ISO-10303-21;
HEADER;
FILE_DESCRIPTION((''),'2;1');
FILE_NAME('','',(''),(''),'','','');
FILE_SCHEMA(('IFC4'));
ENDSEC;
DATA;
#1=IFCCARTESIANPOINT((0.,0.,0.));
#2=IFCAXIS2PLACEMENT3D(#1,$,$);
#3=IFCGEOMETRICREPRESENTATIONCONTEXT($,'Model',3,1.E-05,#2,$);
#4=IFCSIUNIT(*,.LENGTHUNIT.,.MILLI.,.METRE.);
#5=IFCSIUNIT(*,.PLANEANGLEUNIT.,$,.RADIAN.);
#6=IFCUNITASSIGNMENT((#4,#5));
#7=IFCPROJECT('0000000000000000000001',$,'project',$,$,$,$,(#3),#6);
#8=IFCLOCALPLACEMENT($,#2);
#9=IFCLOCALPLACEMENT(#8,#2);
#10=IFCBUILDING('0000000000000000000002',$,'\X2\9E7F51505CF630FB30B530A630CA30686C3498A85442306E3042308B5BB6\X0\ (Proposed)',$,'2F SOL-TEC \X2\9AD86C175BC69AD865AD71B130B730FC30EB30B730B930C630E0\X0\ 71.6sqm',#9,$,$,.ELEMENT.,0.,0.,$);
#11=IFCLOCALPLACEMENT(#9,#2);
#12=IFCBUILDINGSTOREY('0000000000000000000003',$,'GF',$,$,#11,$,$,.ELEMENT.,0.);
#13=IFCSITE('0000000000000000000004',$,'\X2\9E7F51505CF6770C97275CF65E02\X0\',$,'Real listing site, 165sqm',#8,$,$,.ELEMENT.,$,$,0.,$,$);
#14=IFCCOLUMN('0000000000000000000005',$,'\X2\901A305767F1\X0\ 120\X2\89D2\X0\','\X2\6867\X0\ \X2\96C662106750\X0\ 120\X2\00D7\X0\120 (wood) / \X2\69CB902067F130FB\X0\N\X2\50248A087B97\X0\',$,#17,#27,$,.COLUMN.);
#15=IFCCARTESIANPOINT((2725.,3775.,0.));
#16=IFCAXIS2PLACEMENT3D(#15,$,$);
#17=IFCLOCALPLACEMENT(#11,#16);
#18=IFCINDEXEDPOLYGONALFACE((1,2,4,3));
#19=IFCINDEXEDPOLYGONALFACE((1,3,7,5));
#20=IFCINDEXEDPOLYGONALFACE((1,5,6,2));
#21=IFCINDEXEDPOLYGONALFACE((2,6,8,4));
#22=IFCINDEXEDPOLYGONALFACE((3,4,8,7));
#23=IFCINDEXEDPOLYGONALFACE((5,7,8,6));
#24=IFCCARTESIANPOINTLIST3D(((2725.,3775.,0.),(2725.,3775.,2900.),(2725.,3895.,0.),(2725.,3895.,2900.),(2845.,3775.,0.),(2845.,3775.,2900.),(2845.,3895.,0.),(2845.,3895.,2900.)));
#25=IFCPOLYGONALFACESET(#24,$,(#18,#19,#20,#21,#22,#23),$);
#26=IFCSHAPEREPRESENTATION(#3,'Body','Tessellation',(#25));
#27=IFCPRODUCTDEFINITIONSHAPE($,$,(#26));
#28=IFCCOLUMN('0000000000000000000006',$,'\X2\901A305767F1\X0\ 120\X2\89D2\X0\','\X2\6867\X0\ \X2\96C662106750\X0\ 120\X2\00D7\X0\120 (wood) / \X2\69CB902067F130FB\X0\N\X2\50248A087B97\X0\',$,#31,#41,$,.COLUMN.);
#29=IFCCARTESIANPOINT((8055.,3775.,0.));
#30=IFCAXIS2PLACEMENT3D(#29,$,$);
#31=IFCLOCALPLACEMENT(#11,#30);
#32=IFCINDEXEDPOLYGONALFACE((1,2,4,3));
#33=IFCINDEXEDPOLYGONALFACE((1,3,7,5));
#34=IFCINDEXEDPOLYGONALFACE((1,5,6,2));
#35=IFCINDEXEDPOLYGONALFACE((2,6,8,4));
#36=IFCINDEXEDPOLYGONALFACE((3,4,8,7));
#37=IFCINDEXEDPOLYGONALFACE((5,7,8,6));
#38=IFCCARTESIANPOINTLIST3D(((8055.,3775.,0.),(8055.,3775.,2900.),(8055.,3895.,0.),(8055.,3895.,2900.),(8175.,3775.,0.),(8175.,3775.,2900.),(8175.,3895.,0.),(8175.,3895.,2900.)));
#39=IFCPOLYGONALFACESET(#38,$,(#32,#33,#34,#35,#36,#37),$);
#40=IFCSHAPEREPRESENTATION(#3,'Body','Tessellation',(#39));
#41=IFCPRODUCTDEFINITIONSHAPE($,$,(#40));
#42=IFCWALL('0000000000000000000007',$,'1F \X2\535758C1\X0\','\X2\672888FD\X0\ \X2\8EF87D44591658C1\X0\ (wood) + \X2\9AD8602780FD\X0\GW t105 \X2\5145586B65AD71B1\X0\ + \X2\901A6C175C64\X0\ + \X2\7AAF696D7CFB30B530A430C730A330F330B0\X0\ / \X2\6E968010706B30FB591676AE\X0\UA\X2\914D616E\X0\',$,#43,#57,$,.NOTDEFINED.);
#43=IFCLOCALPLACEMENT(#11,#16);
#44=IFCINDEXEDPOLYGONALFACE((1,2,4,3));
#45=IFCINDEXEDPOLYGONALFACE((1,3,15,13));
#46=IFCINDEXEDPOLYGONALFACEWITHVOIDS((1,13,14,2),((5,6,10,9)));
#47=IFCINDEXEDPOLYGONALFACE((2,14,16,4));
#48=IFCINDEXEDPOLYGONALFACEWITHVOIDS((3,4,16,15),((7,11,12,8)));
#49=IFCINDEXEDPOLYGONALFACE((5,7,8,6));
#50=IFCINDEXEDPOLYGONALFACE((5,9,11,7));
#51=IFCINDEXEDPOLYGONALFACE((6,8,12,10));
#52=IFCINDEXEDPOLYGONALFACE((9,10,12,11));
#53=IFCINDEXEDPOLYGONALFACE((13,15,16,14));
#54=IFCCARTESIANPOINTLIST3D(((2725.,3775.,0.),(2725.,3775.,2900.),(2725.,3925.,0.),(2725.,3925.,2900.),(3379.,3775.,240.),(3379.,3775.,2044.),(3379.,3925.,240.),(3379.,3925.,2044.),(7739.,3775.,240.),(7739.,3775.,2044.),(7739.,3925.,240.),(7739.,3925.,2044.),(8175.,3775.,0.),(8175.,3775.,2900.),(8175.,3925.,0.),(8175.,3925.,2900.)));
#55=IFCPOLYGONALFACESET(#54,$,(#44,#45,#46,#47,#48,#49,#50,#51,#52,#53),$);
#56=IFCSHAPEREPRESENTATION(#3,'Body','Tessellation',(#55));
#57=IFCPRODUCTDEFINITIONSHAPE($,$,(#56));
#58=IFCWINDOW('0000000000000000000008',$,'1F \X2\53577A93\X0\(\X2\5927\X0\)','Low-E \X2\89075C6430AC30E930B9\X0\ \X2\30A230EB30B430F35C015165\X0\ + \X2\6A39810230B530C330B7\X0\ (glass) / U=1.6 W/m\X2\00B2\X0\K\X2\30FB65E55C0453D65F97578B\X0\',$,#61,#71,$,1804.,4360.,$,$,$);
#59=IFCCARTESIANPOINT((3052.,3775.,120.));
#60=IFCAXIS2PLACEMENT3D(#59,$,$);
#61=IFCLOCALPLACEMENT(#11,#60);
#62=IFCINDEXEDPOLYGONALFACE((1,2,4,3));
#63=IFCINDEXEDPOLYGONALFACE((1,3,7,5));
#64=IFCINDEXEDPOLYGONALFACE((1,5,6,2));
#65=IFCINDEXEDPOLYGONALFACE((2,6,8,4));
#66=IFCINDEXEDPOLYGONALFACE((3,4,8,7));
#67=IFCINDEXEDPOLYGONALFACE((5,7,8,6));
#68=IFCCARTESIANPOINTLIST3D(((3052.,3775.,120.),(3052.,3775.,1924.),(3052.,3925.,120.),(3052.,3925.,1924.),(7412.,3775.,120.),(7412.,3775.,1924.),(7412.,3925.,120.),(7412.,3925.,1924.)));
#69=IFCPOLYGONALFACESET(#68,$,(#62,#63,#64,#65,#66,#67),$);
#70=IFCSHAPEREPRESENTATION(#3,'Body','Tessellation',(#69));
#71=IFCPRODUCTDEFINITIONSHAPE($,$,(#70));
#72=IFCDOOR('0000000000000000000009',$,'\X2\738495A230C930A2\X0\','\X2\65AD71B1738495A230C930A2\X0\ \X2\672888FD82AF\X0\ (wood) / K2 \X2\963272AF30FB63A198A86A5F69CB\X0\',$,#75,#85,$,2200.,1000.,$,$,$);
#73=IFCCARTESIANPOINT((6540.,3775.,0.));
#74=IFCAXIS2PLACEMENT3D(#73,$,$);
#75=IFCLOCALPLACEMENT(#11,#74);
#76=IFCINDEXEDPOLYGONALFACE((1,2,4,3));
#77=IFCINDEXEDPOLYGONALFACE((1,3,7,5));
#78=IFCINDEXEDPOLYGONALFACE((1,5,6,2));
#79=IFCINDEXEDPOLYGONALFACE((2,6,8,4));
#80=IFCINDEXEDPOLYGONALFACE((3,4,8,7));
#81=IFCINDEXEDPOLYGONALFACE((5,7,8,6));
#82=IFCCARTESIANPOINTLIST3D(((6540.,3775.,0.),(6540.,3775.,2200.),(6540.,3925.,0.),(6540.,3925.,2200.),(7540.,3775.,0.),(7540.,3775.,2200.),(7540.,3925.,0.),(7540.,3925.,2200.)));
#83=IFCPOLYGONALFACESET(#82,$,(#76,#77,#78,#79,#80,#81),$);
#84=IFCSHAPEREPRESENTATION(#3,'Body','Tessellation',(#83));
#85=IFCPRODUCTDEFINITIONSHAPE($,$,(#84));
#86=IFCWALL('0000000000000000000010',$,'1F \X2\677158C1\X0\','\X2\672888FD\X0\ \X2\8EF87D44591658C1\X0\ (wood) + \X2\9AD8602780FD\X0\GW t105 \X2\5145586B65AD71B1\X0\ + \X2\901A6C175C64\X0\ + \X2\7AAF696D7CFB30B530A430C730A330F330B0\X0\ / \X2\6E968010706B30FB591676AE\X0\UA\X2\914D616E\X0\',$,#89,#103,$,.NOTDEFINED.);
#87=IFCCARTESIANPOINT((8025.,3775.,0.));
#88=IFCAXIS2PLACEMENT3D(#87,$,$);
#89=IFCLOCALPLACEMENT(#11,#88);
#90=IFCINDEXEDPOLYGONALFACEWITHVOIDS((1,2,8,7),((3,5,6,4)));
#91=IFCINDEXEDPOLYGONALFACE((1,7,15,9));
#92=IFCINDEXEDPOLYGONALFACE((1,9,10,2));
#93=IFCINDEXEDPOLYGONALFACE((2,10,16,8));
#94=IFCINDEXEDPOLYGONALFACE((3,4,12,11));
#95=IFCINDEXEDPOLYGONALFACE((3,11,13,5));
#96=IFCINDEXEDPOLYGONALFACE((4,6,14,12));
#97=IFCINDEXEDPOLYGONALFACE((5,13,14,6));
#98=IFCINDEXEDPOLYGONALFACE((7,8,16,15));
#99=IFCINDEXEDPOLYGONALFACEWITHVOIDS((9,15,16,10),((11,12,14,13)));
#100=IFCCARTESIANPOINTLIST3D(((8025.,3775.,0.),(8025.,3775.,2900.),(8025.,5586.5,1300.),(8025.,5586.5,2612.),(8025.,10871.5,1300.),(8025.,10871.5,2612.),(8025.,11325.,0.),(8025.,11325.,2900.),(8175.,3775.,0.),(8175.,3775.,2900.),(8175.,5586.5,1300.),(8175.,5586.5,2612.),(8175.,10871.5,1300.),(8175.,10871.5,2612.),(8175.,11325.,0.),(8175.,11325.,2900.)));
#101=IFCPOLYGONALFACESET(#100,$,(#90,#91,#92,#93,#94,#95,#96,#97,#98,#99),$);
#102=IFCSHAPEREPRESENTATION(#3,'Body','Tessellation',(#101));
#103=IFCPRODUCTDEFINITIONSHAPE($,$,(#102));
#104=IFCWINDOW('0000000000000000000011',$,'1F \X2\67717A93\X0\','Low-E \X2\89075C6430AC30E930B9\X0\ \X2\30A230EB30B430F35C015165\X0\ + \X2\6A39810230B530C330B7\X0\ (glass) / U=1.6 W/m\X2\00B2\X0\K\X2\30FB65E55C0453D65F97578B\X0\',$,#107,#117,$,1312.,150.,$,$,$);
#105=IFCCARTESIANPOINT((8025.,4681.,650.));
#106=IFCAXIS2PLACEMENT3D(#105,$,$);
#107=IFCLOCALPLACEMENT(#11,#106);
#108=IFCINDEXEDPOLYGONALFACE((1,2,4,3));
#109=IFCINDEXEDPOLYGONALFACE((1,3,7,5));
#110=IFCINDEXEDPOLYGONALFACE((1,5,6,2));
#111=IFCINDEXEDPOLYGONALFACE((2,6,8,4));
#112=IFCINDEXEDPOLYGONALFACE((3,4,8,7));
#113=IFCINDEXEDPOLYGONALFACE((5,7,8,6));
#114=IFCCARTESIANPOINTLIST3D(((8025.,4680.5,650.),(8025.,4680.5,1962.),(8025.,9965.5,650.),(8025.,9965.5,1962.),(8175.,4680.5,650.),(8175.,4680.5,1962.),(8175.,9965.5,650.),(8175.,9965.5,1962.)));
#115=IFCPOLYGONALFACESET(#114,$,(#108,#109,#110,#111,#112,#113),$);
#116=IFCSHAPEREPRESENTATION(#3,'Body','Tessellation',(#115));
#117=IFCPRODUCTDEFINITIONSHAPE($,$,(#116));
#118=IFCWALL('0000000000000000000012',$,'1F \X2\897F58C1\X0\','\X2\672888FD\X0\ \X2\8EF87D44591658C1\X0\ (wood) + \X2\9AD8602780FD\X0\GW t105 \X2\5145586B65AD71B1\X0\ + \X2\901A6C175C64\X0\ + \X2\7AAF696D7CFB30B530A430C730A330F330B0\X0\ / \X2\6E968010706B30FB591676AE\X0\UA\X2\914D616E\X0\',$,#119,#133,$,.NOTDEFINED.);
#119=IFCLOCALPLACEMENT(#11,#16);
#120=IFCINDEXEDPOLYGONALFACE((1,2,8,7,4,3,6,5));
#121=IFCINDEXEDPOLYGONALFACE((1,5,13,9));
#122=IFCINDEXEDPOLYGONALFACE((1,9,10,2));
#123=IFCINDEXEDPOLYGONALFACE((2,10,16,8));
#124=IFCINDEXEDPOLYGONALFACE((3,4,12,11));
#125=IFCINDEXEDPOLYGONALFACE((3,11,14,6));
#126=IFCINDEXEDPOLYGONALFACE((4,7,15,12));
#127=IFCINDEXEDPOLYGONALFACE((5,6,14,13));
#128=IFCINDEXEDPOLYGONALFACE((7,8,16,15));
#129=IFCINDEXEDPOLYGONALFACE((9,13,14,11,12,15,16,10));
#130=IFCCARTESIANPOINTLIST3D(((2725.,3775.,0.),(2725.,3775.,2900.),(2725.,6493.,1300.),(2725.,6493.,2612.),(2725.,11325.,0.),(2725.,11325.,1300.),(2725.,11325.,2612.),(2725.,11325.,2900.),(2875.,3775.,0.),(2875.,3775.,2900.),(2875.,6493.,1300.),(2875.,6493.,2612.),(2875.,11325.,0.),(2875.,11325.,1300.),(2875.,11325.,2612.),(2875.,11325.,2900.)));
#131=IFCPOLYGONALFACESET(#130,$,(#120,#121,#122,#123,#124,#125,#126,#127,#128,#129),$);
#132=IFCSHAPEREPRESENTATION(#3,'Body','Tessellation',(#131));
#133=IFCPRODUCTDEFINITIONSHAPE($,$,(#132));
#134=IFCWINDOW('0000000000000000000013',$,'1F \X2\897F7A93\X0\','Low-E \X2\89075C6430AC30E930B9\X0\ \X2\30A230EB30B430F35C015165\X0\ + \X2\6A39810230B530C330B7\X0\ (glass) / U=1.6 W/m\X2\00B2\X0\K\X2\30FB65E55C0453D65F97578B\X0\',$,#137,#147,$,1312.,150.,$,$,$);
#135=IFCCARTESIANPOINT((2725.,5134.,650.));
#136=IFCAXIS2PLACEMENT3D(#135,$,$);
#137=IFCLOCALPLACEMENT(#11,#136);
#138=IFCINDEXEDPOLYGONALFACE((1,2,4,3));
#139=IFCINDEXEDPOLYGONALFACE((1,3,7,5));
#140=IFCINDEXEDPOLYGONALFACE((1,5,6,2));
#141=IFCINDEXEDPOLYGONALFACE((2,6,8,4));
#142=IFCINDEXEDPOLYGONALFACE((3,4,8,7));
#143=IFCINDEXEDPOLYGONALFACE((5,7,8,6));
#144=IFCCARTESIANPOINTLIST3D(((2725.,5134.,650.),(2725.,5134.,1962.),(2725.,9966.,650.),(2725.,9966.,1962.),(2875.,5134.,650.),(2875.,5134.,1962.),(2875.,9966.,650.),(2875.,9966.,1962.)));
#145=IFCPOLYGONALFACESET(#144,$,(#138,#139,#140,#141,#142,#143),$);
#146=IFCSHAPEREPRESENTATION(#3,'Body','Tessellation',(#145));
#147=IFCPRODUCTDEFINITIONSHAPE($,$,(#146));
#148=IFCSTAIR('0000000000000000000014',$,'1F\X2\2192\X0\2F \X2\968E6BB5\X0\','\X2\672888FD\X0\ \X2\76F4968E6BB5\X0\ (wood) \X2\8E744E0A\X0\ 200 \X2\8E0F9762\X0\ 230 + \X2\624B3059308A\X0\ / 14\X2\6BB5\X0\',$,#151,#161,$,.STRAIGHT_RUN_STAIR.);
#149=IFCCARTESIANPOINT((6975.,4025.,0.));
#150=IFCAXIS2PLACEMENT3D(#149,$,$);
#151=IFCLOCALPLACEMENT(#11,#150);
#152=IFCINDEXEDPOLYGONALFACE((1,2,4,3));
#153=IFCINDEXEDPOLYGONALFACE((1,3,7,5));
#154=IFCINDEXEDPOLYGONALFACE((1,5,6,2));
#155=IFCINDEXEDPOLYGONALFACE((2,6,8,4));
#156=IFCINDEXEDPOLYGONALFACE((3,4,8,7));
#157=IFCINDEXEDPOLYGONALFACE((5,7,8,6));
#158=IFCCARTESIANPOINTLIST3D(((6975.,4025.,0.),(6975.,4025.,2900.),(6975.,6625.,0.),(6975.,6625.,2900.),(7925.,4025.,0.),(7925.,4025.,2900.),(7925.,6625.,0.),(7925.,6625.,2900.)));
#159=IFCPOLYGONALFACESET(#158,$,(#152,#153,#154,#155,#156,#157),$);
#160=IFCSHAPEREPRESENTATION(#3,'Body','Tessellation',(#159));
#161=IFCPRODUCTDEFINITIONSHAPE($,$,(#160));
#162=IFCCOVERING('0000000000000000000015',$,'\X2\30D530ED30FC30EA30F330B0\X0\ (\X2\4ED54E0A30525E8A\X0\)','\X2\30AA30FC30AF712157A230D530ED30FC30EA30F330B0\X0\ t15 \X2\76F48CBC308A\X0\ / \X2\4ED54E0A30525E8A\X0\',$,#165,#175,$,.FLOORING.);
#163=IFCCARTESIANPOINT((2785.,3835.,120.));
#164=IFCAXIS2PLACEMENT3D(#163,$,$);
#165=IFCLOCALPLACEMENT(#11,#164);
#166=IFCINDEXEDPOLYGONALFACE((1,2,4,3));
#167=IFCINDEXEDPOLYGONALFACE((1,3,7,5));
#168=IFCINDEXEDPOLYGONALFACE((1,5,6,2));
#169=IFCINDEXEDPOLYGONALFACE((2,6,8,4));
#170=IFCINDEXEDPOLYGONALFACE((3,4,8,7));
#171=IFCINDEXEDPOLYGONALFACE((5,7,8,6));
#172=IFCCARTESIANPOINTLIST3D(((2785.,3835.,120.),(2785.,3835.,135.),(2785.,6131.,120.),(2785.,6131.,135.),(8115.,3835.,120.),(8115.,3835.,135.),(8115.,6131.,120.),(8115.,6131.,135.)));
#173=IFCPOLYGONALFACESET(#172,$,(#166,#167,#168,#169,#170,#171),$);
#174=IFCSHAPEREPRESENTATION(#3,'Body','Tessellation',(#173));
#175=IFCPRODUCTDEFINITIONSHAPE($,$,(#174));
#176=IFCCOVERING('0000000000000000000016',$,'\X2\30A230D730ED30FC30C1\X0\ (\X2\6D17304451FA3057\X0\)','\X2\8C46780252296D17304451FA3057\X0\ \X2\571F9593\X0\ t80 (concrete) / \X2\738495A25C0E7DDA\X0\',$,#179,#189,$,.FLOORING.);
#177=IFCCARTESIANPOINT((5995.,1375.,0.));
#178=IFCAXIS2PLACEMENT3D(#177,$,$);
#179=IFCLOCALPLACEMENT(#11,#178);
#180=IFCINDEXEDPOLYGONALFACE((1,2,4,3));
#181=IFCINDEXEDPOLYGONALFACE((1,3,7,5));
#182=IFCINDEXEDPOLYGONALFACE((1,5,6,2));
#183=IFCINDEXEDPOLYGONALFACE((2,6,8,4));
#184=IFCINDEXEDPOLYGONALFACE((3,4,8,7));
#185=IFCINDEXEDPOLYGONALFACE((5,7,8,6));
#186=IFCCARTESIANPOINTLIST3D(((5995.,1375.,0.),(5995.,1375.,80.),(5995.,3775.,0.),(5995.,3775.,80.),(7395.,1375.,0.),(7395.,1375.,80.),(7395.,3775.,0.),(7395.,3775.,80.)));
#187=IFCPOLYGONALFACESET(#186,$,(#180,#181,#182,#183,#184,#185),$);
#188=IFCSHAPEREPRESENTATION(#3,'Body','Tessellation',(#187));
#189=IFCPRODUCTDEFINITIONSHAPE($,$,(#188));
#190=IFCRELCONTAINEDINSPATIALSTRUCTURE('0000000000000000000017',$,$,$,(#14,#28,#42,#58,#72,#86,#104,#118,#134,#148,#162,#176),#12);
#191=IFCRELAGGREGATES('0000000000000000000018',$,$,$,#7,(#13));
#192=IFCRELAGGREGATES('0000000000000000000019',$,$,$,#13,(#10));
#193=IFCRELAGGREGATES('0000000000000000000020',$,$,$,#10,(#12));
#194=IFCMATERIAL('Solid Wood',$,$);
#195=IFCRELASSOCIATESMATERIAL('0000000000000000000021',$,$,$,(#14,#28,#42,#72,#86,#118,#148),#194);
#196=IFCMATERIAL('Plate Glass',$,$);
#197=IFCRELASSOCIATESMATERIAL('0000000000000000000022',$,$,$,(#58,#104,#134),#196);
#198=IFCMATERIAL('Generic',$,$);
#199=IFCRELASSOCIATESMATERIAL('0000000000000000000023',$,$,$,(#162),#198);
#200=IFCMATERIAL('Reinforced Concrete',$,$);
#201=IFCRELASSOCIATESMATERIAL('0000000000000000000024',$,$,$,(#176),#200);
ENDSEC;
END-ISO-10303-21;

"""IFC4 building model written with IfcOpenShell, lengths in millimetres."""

from ifc_helpers import new_model, si_unit, frame, frame_2d, origin, place, context, project, spatial, rectangle, extrude, material, element, fill, save


model = new_model("IFC4")

# Units and contexts
model_context = context("Model", 3, precision=1e-05, world=origin())
ifc_project = project(units=[si_unit("LENGTHUNIT", "METRE", prefix="MILLI"), si_unit("PLANEANGLEUNIT", "RADIAN")], contexts=[model_context])

# Site, building, storey
site_placement = place(None, origin())
site = spatial("IfcSite", under=ifc_project, at=site_placement, Name="鹿児島県霧島市", ObjectType="Real listing site, 165sqm", CompositionType="ELEMENT", RefElevation=0.0)
building_placement = place(site_placement, origin())
building = spatial("IfcBuilding", under=site, at=building_placement, Name="鹿児島・サウナと水風呂のある家 (Proposed)", ObjectType="2F SOL-TEC 高気密高断熱シールシステム 71.6sqm", CompositionType="ELEMENT", ElevationOfRefHeight=0.0, ElevationOfTerrain=0.0)
storey_placement = place(building_placement, origin())
storey = spatial("IfcBuildingStorey", under=building, at=storey_placement, Name="GF", CompositionType="ELEMENT", Elevation=0.0)

# Columns
ifc_material_1 = material(Name="Solid Wood")
column_1_placement = place(storey_placement, frame((2725.0, 3775.0, 0.0)))
element("IfcColumn", 1, at=column_1_placement, inside=storey, material=ifc_material_1, Name="通し柱 120角", Description="桧 集成材 120×120 (wood) / 構造柱・N値計算", PredefinedType="COLUMN", context=model_context, shape_type="SweptSolid", body=[
    extrude(rectangle(XDim=120.0, YDim=120.0, at=frame_2d((60.0, 60.0))), frame((2725.0, 3775.0, 0.0)), (0.0, 0.0, 1.0), 2900.0),
])
column_2_placement = place(storey_placement, frame((8055.0, 3775.0, 0.0)))
element("IfcColumn", 2, at=column_2_placement, inside=storey, material=ifc_material_1, Name="通し柱 120角", Description="桧 集成材 120×120 (wood) / 構造柱・N値計算", PredefinedType="COLUMN", context=model_context, shape_type="SweptSolid", body=[
    extrude(rectangle(XDim=120.0, YDim=120.0, at=frame_2d((60.0, 60.0))), frame((8055.0, 3775.0, 0.0)), (0.0, 0.0, 1.0), 2900.0),
])

# Shared definitions
ifc_material_2 = material(Name="Reinforced Concrete")

# Wall, openings, window, door
wall_1_placement = place(storey_placement, frame((2725.0, 3775.0, 0.0)))
wall_1 = element("IfcWall", 3, at=wall_1_placement, inside=storey, material=ifc_material_1, Name="1F 南壁", Description="木製 軸組外壁 (wood) + 高性能GW t105 充填断熱 + 通気層 + 窯業系サイディング / 準耐火・外皮UA配慮", PredefinedType="NOTDEFINED", context=model_context, shape_type="SweptSolid", body=[
    extrude(rectangle(XDim=5450.0, YDim=150.0, at=frame_2d((2725.0, 75.0))), frame((2725.0, 3775.0, 0.0)), (0.0, 0.0, 1.0), 2900.0),
])
opening_1_placement = place(storey_placement, frame((3052.0, 3775.0, 120.0)))
opening_1 = element("IfcOpeningElement", 4, at=opening_1_placement, cuts=wall_1, PredefinedType="NOTDEFINED", context=model_context, shape_type="SweptSolid", body=[
    extrude(rectangle(XDim=4360.0, YDim=150.0, at=frame_2d((2180.0, 75.0))), frame((3052.0, 3775.0, 120.0)), (0.0, 0.0, 1.0), 1804.0),
])
opening_2_placement = place(storey_placement, frame((6540.0, 3775.0, 0.0)))
opening_2 = element("IfcOpeningElement", 5, at=opening_2_placement, cuts=wall_1, PredefinedType="NOTDEFINED", context=model_context, shape_type="SweptSolid", body=[
    extrude(rectangle(XDim=1000.0, YDim=150.0, at=frame_2d((500.0, 75.0))), frame((6540.0, 3775.0, 0.0)), (0.0, 0.0, 1.0), 2200.0),
])
ifc_material_3 = material(Name="Plate Glass")
window_1_placement = place(storey_placement, frame((3052.0, 3775.0, 120.0)))
window_1 = element("IfcWindow", 6, at=window_1_placement, inside=storey, material=ifc_material_3, Name="1F 南窓(大)", Description="Low-E 複層ガラス アルゴン封入 + 樹脂サッシ (glass) / U=1.6 W/m²K・日射取得型", OverallHeight=1804.0, OverallWidth=4360.0, context=model_context, shape_type="SweptSolid", body=[
    extrude(rectangle(XDim=4360.0, YDim=150.0, at=frame_2d((2180.0, 75.0))), frame((3052.0, 3775.0, 120.0)), (0.0, 0.0, 1.0), 1804.0),
])
fill(opening_1, window_1)
door_placement = place(storey_placement, frame((6540.0, 3775.0, 0.0)))
door = element("IfcDoor", 7, at=door_placement, inside=storey, material=ifc_material_1, Name="玄関ドア", Description="断熱玄関ドア 木製芯 (wood) / K2 防犯・採風機構", OverallHeight=2200.0, OverallWidth=1000.0, context=model_context, shape_type="SweptSolid", body=[
    extrude(rectangle(XDim=1000.0, YDim=150.0, at=frame_2d((500.0, 75.0))), frame((6540.0, 3775.0, 0.0)), (0.0, 0.0, 1.0), 2200.0),
])
fill(opening_2, door)

# Walls, openings, windows
wall_2_placement = place(storey_placement, frame((8025.0, 3775.0, 0.0)))
wall_2 = element("IfcWall", 8, at=wall_2_placement, inside=storey, material=ifc_material_1, Name="1F 東壁", Description="木製 軸組外壁 (wood) + 高性能GW t105 充填断熱 + 通気層 + 窯業系サイディング / 準耐火・外皮UA配慮", PredefinedType="NOTDEFINED", context=model_context, shape_type="SweptSolid", body=[
    extrude(rectangle(XDim=150.0, YDim=7550.0, at=frame_2d((75.0, 3775.0))), frame((8025.0, 3775.0, 0.0)), (0.0, 0.0, 1.0), 2900.0),
])
opening_3_placement = place(storey_placement, frame((8025.0, 4681.0, 650.0)))
opening_3 = element("IfcOpeningElement", 9, at=opening_3_placement, cuts=wall_2, PredefinedType="NOTDEFINED", context=model_context, shape_type="SweptSolid", body=[
    extrude(rectangle(XDim=150.0, YDim=5285.0, at=frame_2d((75.0, 2642.0))), frame((8025.0, 4681.0, 650.0)), (0.0, 0.0, 1.0), 1312.0),
])
window_2_placement = place(storey_placement, frame((8025.0, 4681.0, 650.0)))
window_2 = element("IfcWindow", 10, at=window_2_placement, inside=storey, material=ifc_material_3, Name="1F 東窓", Description="Low-E 複層ガラス アルゴン封入 + 樹脂サッシ (glass) / U=1.6 W/m²K・日射取得型", OverallHeight=1312.0, OverallWidth=150.0, context=model_context, shape_type="SweptSolid", body=[
    extrude(rectangle(XDim=150.0, YDim=5285.0, at=frame_2d((75.0, 2642.0))), frame((8025.0, 4681.0, 650.0)), (0.0, 0.0, 1.0), 1312.0),
])
fill(opening_3, window_2)
wall_3_placement = place(storey_placement, frame((2725.0, 3775.0, 0.0)))
wall_3 = element("IfcWall", 11, at=wall_3_placement, inside=storey, material=ifc_material_1, Name="1F 西壁", Description="木製 軸組外壁 (wood) + 高性能GW t105 充填断熱 + 通気層 + 窯業系サイディング / 準耐火・外皮UA配慮", PredefinedType="NOTDEFINED", context=model_context, shape_type="SweptSolid", body=[
    extrude(rectangle(XDim=150.0, YDim=7550.0, at=frame_2d((75.0, 3775.0))), frame((2725.0, 3775.0, 0.0)), (0.0, 0.0, 1.0), 2900.0),
])
opening_4_placement = place(storey_placement, frame((2725.0, 5134.0, 650.0)))
opening_4 = element("IfcOpeningElement", 12, at=opening_4_placement, cuts=wall_3, PredefinedType="NOTDEFINED", context=model_context, shape_type="SweptSolid", body=[
    extrude(rectangle(XDim=150.0, YDim=4832.0, at=frame_2d((75.0, 2416.0))), frame((2725.0, 5134.0, 650.0)), (0.0, 0.0, 1.0), 1312.0),
])
window_3_placement = place(storey_placement, frame((2725.0, 5134.0, 650.0)))
window_3 = element("IfcWindow", 13, at=window_3_placement, inside=storey, material=ifc_material_3, Name="1F 西窓", Description="Low-E 複層ガラス アルゴン封入 + 樹脂サッシ (glass) / U=1.6 W/m²K・日射取得型", OverallHeight=1312.0, OverallWidth=150.0, context=model_context, shape_type="SweptSolid", body=[
    extrude(rectangle(XDim=150.0, YDim=4832.0, at=frame_2d((75.0, 2416.0))), frame((2725.0, 5134.0, 650.0)), (0.0, 0.0, 1.0), 1312.0),
])
fill(opening_4, window_3)

# Stair
stair_placement = place(storey_placement, frame((6975.0, 4025.0, 0.0)))
element("IfcStair", 14, at=stair_placement, inside=storey, material=ifc_material_1, Name="1F→2F 階段", Description="木製 直階段 (wood) 蹴上 200 踏面 230 + 手すり / 14段", PredefinedType="STRAIGHT_RUN_STAIR", context=model_context, shape_type="SweptSolid", body=[
    extrude(rectangle(XDim=950.0, YDim=2600.0, at=frame_2d((475.0, 1300.0))), frame((6975.0, 4025.0, 0.0)), (0.0, 0.0, 1.0), 2900.0),
])

# Coverings
ifc_material_4 = material(Name="Generic")
covering_1_placement = place(storey_placement, frame((2785.0, 3835.0, 120.0)))
element("IfcCovering", 15, at=covering_1_placement, inside=storey, material=ifc_material_4, Name="フローリング (仕上げ床)", Description="オーク無垢フローリング t15 直貼り / 仕上げ床", PredefinedType="FLOORING", context=model_context, shape_type="SweptSolid", body=[
    extrude(rectangle(XDim=5330.0, YDim=2296.0, at=frame_2d((2665.0, 1148.0))), frame((2785.0, 3835.0, 120.0)), (0.0, 0.0, 1.0), 15.0),
])
covering_2_placement = place(storey_placement, frame((5995.0, 1375.0, 0.0)))
element("IfcCovering", 16, at=covering_2_placement, inside=storey, material=ifc_material_2, Name="アプローチ (洗い出し)", Description="豆砂利洗い出し 土間 t80 (concrete) / 玄関導線", PredefinedType="FLOORING", context=model_context, shape_type="SweptSolid", body=[
    extrude(rectangle(XDim=1400.0, YDim=2400.0, at=frame_2d((700.0, 1200.0))), frame((5995.0, 1375.0, 0.0)), (0.0, 0.0, 1.0), 80.0),
])

save(model, "model.ifc")
